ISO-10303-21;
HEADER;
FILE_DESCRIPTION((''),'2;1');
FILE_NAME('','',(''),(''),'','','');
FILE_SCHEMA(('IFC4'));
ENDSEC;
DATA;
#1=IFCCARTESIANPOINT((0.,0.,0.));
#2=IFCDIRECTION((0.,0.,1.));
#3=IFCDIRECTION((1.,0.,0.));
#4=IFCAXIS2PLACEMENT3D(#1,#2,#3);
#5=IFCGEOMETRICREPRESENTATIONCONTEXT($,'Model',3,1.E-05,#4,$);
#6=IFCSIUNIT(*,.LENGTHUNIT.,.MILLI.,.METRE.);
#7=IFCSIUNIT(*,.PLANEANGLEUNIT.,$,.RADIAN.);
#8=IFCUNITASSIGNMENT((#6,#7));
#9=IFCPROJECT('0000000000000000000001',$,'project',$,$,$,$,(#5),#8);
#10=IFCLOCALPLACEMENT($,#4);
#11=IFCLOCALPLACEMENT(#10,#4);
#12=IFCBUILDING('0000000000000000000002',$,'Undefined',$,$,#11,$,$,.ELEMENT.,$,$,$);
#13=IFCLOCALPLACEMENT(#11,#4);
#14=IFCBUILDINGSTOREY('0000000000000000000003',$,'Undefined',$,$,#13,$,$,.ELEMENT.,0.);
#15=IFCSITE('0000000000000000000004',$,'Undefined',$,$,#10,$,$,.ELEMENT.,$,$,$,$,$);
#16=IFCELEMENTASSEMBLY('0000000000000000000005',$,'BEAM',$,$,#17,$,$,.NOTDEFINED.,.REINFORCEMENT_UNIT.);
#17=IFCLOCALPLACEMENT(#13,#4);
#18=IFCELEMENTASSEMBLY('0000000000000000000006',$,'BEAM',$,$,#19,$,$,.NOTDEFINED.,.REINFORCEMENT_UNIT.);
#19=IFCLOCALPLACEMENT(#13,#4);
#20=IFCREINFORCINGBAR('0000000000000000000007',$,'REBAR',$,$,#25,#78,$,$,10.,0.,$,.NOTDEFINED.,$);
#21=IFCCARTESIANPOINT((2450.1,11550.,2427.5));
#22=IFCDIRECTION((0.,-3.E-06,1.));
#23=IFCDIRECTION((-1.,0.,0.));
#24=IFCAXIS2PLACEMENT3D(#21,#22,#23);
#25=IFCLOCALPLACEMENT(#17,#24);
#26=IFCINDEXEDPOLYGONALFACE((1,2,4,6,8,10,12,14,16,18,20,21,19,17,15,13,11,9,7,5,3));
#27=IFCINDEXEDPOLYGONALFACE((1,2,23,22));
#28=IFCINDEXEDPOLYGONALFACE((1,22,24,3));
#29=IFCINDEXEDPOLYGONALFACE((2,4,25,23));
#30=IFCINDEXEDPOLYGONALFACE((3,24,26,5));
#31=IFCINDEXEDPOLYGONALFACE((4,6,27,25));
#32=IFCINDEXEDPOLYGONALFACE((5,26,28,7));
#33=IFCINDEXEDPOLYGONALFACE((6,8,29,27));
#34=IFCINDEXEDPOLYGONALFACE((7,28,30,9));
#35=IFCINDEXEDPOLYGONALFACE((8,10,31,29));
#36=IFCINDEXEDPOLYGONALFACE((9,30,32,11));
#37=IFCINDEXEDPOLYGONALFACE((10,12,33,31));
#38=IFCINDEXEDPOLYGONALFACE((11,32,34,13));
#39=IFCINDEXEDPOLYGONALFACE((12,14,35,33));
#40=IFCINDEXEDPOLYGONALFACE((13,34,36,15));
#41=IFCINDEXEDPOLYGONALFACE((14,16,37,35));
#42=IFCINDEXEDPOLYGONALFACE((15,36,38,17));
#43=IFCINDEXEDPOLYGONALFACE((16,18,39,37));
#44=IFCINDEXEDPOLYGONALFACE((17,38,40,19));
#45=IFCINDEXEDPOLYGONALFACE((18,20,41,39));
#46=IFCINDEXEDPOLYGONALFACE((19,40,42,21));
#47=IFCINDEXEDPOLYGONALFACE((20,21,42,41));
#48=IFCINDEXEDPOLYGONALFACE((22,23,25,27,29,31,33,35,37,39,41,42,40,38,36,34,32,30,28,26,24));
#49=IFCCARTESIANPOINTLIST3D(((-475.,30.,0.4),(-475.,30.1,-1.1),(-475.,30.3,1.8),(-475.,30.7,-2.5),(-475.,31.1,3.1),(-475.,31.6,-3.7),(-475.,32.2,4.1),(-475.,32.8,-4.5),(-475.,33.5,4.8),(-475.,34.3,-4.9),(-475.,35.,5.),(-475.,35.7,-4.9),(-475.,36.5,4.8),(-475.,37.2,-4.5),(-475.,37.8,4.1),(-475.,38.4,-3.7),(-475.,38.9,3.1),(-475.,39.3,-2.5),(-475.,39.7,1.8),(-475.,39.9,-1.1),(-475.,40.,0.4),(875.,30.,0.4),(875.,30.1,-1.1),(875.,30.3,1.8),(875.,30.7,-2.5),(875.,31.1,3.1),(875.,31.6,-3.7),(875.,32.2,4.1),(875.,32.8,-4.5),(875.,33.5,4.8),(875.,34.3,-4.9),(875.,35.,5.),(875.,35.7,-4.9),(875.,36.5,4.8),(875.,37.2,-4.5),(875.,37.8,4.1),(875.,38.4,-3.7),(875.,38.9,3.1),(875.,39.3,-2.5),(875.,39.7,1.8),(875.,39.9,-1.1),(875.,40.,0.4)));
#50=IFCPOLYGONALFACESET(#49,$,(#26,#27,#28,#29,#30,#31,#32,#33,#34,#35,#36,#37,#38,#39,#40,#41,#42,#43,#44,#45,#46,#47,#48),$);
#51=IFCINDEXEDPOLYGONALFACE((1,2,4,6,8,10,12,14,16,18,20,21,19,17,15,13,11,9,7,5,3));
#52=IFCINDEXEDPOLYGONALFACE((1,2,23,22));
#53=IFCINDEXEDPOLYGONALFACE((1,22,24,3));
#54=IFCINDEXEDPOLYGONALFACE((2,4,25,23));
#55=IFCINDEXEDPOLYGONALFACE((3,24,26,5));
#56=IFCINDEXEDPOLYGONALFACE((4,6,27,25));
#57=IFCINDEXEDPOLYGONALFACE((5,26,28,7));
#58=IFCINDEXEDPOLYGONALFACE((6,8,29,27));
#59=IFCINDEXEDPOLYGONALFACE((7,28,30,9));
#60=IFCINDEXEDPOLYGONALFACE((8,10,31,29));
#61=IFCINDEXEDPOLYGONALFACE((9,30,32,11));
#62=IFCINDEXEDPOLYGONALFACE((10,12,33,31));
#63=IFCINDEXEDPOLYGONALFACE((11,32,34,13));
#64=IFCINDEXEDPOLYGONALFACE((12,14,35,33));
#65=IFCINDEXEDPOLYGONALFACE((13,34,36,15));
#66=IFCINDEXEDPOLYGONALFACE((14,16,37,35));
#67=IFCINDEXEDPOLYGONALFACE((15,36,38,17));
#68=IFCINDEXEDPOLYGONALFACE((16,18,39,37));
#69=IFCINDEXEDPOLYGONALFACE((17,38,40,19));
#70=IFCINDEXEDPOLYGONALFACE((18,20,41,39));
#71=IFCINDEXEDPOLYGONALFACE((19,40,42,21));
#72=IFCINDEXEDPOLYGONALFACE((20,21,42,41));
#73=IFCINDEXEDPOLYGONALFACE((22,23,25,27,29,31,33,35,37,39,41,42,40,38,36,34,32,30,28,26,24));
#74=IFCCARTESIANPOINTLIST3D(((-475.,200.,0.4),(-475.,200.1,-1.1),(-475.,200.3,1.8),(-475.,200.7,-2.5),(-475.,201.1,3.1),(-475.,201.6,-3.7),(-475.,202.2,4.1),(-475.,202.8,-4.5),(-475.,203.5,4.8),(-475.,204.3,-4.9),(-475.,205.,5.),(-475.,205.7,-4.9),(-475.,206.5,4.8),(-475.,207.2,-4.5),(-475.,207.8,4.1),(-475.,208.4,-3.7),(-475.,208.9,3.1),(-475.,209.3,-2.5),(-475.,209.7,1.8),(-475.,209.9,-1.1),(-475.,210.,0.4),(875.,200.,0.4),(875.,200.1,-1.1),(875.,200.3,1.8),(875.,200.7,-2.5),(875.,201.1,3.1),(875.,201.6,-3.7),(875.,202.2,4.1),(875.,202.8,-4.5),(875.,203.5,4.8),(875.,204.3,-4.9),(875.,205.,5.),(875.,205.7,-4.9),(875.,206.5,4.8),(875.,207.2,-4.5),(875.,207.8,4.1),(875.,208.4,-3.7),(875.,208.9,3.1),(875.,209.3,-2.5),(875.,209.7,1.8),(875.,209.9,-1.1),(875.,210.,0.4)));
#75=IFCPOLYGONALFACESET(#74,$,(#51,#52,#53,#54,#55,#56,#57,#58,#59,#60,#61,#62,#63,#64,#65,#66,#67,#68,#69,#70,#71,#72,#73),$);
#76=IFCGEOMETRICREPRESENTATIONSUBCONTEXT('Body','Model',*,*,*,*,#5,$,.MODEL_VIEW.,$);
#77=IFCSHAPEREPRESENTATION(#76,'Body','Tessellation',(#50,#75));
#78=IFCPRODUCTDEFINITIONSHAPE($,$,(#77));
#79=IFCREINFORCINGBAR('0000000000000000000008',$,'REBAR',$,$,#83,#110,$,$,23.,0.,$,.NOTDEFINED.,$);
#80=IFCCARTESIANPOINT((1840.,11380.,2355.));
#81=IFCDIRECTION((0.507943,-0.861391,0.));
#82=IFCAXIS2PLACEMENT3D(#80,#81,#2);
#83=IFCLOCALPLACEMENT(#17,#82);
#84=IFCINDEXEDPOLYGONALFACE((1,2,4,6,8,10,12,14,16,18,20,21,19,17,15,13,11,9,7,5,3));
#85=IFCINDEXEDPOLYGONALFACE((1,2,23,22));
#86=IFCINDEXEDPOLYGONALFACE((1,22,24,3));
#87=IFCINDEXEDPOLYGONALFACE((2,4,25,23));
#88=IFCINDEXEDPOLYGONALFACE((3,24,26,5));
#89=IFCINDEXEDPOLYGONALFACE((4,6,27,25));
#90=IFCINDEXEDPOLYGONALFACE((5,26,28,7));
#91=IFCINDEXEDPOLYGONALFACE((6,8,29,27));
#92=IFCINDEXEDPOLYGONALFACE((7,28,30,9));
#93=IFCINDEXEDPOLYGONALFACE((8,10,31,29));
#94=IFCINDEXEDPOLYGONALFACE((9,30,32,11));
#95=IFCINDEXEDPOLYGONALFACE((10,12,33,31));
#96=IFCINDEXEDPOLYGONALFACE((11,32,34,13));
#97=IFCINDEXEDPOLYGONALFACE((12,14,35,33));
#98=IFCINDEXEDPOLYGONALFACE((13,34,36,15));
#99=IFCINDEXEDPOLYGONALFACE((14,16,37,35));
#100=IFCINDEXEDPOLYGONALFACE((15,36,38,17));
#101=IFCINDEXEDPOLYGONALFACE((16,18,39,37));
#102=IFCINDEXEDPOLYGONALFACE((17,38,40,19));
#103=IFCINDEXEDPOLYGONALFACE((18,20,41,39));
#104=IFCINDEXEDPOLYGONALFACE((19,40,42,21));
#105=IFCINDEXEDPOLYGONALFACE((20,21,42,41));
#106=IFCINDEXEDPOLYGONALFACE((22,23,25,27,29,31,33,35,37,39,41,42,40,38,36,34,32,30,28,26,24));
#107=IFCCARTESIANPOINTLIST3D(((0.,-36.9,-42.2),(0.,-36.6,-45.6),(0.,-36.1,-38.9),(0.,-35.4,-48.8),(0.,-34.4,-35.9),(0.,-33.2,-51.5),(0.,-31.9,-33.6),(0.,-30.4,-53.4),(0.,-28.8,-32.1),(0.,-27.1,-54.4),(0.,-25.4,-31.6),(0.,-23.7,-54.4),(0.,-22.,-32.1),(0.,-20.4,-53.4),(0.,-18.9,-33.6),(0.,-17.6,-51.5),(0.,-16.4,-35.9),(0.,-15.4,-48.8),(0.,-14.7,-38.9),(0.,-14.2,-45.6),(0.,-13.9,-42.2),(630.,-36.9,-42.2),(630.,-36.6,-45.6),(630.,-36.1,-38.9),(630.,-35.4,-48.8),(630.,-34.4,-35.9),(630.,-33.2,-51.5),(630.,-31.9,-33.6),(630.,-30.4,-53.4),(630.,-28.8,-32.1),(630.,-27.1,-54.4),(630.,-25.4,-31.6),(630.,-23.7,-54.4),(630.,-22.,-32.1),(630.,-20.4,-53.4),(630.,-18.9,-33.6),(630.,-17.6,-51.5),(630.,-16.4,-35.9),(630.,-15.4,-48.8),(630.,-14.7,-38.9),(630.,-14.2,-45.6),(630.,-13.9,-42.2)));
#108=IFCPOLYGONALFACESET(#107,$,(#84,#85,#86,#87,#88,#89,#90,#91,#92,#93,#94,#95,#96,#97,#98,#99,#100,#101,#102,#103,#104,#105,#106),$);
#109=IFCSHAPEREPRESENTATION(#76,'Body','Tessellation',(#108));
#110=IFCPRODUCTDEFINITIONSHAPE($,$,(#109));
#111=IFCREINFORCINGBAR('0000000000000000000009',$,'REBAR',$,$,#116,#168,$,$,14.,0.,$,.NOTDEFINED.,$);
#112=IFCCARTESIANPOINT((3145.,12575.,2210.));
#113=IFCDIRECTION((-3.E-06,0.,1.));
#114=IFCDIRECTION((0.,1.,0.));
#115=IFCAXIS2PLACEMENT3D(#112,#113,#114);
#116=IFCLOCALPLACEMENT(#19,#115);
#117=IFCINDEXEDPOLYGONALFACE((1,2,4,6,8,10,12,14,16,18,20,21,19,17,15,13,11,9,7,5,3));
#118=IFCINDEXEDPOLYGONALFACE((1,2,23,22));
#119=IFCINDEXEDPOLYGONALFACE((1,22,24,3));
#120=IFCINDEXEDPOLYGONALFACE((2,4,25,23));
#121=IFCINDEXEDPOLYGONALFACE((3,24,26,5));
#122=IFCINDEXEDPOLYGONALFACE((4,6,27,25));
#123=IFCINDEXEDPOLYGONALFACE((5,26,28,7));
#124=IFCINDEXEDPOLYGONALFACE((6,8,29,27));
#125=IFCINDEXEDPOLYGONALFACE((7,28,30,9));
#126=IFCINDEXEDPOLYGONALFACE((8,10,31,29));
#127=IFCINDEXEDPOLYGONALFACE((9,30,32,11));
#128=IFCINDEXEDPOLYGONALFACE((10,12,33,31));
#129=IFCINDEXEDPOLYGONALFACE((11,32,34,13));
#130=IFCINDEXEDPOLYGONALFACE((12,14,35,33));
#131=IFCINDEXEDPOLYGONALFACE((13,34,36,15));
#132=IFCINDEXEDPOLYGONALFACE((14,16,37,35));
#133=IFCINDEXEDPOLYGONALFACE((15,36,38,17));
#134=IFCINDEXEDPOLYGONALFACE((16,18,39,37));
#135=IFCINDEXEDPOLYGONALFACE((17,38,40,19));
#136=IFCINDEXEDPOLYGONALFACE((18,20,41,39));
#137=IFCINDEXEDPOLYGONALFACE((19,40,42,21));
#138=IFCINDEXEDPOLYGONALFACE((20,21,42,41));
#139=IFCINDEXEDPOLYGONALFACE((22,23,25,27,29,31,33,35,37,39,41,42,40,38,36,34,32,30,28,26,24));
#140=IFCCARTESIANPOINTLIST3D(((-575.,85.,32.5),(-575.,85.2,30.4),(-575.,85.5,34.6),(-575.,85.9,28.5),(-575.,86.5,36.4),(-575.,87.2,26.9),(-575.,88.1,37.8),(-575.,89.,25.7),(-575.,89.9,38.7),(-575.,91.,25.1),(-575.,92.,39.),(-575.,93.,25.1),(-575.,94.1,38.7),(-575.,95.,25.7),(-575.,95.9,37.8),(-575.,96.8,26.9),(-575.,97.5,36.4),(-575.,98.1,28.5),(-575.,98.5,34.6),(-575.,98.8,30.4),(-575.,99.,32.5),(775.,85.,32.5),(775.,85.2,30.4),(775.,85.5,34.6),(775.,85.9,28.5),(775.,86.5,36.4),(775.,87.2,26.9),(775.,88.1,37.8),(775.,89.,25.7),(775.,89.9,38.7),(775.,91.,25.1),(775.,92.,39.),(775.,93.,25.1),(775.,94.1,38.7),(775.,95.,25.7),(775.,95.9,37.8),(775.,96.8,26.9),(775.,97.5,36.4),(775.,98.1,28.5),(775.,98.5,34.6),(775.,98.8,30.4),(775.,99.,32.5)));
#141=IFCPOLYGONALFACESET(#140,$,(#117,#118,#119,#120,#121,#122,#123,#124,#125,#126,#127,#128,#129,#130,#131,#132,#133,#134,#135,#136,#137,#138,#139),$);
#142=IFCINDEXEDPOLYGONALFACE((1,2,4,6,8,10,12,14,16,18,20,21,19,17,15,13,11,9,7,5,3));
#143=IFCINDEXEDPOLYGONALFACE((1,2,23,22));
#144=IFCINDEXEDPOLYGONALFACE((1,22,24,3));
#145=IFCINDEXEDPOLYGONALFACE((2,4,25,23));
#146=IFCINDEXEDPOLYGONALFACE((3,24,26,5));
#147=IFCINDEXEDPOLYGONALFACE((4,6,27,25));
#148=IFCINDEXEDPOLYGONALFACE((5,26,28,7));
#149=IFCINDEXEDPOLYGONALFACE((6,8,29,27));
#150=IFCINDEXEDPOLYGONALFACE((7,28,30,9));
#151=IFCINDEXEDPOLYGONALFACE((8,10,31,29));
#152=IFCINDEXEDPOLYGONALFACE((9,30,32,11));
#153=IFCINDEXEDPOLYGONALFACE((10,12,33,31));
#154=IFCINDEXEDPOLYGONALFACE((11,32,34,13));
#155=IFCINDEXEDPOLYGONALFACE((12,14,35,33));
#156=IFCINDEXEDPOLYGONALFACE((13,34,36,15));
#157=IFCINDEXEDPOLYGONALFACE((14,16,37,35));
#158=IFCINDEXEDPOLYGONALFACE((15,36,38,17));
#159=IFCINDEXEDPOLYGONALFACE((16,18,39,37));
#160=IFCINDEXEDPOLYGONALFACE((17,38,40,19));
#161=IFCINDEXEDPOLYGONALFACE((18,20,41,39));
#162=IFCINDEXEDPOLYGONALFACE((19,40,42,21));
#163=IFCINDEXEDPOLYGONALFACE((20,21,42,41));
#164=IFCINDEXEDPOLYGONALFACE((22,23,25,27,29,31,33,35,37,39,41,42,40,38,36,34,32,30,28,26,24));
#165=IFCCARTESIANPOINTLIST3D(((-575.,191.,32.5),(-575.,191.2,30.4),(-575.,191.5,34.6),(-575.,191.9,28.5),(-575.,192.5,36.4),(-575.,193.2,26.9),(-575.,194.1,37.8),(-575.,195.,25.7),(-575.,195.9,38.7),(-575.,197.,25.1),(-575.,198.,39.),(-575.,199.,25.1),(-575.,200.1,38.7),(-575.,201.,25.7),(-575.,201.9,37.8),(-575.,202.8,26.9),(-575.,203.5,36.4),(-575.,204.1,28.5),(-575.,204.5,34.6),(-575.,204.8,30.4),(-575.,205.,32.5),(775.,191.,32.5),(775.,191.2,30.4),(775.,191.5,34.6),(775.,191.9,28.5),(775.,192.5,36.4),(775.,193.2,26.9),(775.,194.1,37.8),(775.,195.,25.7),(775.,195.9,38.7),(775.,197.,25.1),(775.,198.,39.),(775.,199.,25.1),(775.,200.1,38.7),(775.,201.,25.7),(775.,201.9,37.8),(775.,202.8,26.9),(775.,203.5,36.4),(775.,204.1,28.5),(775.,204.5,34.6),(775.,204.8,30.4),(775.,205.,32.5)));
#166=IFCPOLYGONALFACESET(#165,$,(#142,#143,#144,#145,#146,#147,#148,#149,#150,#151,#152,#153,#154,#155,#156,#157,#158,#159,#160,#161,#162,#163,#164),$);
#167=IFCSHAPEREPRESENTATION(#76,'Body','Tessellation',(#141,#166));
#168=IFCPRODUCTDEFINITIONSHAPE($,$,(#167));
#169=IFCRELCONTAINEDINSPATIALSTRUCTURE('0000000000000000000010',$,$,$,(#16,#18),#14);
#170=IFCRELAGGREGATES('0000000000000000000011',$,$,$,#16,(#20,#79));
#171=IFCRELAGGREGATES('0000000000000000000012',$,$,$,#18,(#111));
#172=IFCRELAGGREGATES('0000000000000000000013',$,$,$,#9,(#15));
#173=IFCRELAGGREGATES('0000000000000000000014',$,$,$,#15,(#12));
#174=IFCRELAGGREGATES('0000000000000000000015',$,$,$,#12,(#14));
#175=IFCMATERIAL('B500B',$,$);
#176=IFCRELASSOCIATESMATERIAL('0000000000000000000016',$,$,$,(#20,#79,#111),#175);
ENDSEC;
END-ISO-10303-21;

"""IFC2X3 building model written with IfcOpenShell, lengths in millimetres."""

from ifc_helpers import new_model, entity, si_unit, frame, origin_with_axes, place, context, subcontext, project, spatial, source, transform, mapped, material, element, aggregate, save


model = new_model("IFC2X3")

# Units and contexts
model_context = context("Model", 3, precision=1e-05, world=origin_with_axes())
body_context = subcontext(model_context, "Body", "Model", "MODEL_VIEW")
ifc_project = project(units=[si_unit("LENGTHUNIT", "METRE", prefix="MILLI"), si_unit("PLANEANGLEUNIT", "RADIAN")], contexts=[model_context])

# Site, building, storey
site_placement = place(None, origin_with_axes())
site = spatial("IfcSite", under=ifc_project, at=site_placement, Name="Undefined", CompositionType="ELEMENT")
building_placement = place(site_placement, origin_with_axes())
building = spatial("IfcBuilding", under=site, at=building_placement, Name="Undefined", CompositionType="ELEMENT")
storey_placement = place(building_placement, origin_with_axes())
storey = spatial("IfcBuildingStorey", under=building, at=storey_placement, Name="Undefined", CompositionType="ELEMENT", Elevation=0.0)

# Element assemblies
assembly_1_placement = place(storey_placement, origin_with_axes())
assembly_1 = element("IfcElementAssembly", 1, at=assembly_1_placement, inside=storey, Name="BEAM", AssemblyPlace="NOTDEFINED", PredefinedType="REINFORCEMENT_UNIT")
assembly_2_placement = place(storey_placement, origin_with_axes())
assembly_2 = element("IfcElementAssembly", 2, at=assembly_2_placement, inside=storey, Name="BEAM", AssemblyPlace="NOTDEFINED", PredefinedType="REINFORCEMENT_UNIT")

# Reinforcing bars
ifc_material_1 = material(Name="B500B")
shared_shape_1 = source(origin_with_axes(), body_context, "Body", "AdvancedSweptSolid", [
    entity("IfcSweptDiskSolid", entity("IfcTrimmedCurve", entity("IfcLine", entity("IfcCartesianPoint", [0.0, 0.0, 0.0]), entity("IfcVector", entity("IfcDirection", [1.0, 0.0, 0.0]), 1.0)), [entity("IfcParameterValue", 0.0)], [entity("IfcParameterValue", 1349.999613)], True, "PARAMETER"), 5.0, None, 0.0, 1350.0),
])
shared_shape_2 = source(origin_with_axes(), body_context, "Body", "AdvancedSweptSolid", [
    entity("IfcSweptDiskSolid", entity("IfcTrimmedCurve", entity("IfcLine", entity("IfcCartesianPoint", [0.0, 0.0, 0.0]), entity("IfcVector", entity("IfcDirection", [1.0, 0.0, 0.0]), 1.0)), [entity("IfcParameterValue", 0.0)], [entity("IfcParameterValue", 1349.999613)], True, "PARAMETER"), 5.0, None, 0.0, 1350.0),
])
reinforcing_bar_1_placement = place(assembly_1_placement, frame((2450.1, 11550.0, 2427.5), z_axis=(0.0, -0.000003, 1.0), x_axis=(-1.0, 0.0, 0.0)))
reinforcing_bar_1 = element("IfcReinforcingBar", 3, at=reinforcing_bar_1_placement, material=ifc_material_1, Name="REBAR", BarRole="NOTDEFINED", CrossSectionArea=0.0, NominalDiameter=10.0, context=body_context, shape_type="MappedRepresentation", body=[
    mapped(shared_shape_1, transform((-475.0, 35.0, 0.0))),
    mapped(shared_shape_2, transform((-475.0, 205.0, 0.0))),
])
shared_shape_3 = source(origin_with_axes(), body_context, "Body", "AdvancedSweptSolid", [
    entity("IfcSweptDiskSolid", entity("IfcTrimmedCurve", entity("IfcLine", entity("IfcCartesianPoint", [0.0, 0.0, 0.0]), entity("IfcVector", entity("IfcDirection", [1.0, 0.0, 0.0]), 1.0)), [entity("IfcParameterValue", 0.0)], [entity("IfcParameterValue", 630.0)], True, "PARAMETER"), 11.5, None, 0.0, 630.0),
])
reinforcing_bar_2_placement = place(assembly_1_placement, frame((1840.0, 11380.0, 2355.0), z_axis=(0.507943, -0.861391, 0.0), x_axis=(0.0, 0.0, 1.0)))
reinforcing_bar_2 = element("IfcReinforcingBar", 4, at=reinforcing_bar_2_placement, material=ifc_material_1, Name="REBAR", BarRole="NOTDEFINED", CrossSectionArea=0.0, NominalDiameter=23.0, context=body_context, shape_type="MappedRepresentation", body=[
    mapped(shared_shape_3, transform((0.0, -25.4, -43.1))),
])
aggregate(assembly_1, [reinforcing_bar_1, reinforcing_bar_2])
shared_shape_4 = source(origin_with_axes(), body_context, "Body", "AdvancedSweptSolid", [
    entity("IfcSweptDiskSolid", entity("IfcTrimmedCurve", entity("IfcLine", entity("IfcCartesianPoint", [0.0, 0.0, 0.0]), entity("IfcVector", entity("IfcDirection", [1.0, 0.0, 0.0]), 1.0)), [entity("IfcParameterValue", 0.0)], [entity("IfcParameterValue", 1349.999613)], True, "PARAMETER"), 7.0, None, 0.0, 1350.0),
])
shared_shape_5 = source(origin_with_axes(), body_context, "Body", "AdvancedSweptSolid", [
    entity("IfcSweptDiskSolid", entity("IfcTrimmedCurve", entity("IfcLine", entity("IfcCartesianPoint", [0.0, 0.0, 0.0]), entity("IfcVector", entity("IfcDirection", [1.0, 0.0, 0.0]), 1.0)), [entity("IfcParameterValue", 0.0)], [entity("IfcParameterValue", 1349.999613)], True, "PARAMETER"), 7.0, None, 0.0, 1350.0),
])
reinforcing_bar_3_placement = place(assembly_2_placement, frame((3145.0, 12575.0, 2210.0), z_axis=(-0.000003, 0.0, 1.0), x_axis=(0.0, 1.0, 0.0)))
reinforcing_bar_3 = element("IfcReinforcingBar", 5, at=reinforcing_bar_3_placement, material=ifc_material_1, Name="REBAR", BarRole="NOTDEFINED", CrossSectionArea=0.0, NominalDiameter=14.0, context=body_context, shape_type="MappedRepresentation", body=[
    mapped(shared_shape_4, transform((-575.0, 92.0, 32.0))),
    mapped(shared_shape_5, transform((-575.0, 198.0, 32.0))),
])
aggregate(assembly_2, [reinforcing_bar_3])

save(model, "model.ifc")
